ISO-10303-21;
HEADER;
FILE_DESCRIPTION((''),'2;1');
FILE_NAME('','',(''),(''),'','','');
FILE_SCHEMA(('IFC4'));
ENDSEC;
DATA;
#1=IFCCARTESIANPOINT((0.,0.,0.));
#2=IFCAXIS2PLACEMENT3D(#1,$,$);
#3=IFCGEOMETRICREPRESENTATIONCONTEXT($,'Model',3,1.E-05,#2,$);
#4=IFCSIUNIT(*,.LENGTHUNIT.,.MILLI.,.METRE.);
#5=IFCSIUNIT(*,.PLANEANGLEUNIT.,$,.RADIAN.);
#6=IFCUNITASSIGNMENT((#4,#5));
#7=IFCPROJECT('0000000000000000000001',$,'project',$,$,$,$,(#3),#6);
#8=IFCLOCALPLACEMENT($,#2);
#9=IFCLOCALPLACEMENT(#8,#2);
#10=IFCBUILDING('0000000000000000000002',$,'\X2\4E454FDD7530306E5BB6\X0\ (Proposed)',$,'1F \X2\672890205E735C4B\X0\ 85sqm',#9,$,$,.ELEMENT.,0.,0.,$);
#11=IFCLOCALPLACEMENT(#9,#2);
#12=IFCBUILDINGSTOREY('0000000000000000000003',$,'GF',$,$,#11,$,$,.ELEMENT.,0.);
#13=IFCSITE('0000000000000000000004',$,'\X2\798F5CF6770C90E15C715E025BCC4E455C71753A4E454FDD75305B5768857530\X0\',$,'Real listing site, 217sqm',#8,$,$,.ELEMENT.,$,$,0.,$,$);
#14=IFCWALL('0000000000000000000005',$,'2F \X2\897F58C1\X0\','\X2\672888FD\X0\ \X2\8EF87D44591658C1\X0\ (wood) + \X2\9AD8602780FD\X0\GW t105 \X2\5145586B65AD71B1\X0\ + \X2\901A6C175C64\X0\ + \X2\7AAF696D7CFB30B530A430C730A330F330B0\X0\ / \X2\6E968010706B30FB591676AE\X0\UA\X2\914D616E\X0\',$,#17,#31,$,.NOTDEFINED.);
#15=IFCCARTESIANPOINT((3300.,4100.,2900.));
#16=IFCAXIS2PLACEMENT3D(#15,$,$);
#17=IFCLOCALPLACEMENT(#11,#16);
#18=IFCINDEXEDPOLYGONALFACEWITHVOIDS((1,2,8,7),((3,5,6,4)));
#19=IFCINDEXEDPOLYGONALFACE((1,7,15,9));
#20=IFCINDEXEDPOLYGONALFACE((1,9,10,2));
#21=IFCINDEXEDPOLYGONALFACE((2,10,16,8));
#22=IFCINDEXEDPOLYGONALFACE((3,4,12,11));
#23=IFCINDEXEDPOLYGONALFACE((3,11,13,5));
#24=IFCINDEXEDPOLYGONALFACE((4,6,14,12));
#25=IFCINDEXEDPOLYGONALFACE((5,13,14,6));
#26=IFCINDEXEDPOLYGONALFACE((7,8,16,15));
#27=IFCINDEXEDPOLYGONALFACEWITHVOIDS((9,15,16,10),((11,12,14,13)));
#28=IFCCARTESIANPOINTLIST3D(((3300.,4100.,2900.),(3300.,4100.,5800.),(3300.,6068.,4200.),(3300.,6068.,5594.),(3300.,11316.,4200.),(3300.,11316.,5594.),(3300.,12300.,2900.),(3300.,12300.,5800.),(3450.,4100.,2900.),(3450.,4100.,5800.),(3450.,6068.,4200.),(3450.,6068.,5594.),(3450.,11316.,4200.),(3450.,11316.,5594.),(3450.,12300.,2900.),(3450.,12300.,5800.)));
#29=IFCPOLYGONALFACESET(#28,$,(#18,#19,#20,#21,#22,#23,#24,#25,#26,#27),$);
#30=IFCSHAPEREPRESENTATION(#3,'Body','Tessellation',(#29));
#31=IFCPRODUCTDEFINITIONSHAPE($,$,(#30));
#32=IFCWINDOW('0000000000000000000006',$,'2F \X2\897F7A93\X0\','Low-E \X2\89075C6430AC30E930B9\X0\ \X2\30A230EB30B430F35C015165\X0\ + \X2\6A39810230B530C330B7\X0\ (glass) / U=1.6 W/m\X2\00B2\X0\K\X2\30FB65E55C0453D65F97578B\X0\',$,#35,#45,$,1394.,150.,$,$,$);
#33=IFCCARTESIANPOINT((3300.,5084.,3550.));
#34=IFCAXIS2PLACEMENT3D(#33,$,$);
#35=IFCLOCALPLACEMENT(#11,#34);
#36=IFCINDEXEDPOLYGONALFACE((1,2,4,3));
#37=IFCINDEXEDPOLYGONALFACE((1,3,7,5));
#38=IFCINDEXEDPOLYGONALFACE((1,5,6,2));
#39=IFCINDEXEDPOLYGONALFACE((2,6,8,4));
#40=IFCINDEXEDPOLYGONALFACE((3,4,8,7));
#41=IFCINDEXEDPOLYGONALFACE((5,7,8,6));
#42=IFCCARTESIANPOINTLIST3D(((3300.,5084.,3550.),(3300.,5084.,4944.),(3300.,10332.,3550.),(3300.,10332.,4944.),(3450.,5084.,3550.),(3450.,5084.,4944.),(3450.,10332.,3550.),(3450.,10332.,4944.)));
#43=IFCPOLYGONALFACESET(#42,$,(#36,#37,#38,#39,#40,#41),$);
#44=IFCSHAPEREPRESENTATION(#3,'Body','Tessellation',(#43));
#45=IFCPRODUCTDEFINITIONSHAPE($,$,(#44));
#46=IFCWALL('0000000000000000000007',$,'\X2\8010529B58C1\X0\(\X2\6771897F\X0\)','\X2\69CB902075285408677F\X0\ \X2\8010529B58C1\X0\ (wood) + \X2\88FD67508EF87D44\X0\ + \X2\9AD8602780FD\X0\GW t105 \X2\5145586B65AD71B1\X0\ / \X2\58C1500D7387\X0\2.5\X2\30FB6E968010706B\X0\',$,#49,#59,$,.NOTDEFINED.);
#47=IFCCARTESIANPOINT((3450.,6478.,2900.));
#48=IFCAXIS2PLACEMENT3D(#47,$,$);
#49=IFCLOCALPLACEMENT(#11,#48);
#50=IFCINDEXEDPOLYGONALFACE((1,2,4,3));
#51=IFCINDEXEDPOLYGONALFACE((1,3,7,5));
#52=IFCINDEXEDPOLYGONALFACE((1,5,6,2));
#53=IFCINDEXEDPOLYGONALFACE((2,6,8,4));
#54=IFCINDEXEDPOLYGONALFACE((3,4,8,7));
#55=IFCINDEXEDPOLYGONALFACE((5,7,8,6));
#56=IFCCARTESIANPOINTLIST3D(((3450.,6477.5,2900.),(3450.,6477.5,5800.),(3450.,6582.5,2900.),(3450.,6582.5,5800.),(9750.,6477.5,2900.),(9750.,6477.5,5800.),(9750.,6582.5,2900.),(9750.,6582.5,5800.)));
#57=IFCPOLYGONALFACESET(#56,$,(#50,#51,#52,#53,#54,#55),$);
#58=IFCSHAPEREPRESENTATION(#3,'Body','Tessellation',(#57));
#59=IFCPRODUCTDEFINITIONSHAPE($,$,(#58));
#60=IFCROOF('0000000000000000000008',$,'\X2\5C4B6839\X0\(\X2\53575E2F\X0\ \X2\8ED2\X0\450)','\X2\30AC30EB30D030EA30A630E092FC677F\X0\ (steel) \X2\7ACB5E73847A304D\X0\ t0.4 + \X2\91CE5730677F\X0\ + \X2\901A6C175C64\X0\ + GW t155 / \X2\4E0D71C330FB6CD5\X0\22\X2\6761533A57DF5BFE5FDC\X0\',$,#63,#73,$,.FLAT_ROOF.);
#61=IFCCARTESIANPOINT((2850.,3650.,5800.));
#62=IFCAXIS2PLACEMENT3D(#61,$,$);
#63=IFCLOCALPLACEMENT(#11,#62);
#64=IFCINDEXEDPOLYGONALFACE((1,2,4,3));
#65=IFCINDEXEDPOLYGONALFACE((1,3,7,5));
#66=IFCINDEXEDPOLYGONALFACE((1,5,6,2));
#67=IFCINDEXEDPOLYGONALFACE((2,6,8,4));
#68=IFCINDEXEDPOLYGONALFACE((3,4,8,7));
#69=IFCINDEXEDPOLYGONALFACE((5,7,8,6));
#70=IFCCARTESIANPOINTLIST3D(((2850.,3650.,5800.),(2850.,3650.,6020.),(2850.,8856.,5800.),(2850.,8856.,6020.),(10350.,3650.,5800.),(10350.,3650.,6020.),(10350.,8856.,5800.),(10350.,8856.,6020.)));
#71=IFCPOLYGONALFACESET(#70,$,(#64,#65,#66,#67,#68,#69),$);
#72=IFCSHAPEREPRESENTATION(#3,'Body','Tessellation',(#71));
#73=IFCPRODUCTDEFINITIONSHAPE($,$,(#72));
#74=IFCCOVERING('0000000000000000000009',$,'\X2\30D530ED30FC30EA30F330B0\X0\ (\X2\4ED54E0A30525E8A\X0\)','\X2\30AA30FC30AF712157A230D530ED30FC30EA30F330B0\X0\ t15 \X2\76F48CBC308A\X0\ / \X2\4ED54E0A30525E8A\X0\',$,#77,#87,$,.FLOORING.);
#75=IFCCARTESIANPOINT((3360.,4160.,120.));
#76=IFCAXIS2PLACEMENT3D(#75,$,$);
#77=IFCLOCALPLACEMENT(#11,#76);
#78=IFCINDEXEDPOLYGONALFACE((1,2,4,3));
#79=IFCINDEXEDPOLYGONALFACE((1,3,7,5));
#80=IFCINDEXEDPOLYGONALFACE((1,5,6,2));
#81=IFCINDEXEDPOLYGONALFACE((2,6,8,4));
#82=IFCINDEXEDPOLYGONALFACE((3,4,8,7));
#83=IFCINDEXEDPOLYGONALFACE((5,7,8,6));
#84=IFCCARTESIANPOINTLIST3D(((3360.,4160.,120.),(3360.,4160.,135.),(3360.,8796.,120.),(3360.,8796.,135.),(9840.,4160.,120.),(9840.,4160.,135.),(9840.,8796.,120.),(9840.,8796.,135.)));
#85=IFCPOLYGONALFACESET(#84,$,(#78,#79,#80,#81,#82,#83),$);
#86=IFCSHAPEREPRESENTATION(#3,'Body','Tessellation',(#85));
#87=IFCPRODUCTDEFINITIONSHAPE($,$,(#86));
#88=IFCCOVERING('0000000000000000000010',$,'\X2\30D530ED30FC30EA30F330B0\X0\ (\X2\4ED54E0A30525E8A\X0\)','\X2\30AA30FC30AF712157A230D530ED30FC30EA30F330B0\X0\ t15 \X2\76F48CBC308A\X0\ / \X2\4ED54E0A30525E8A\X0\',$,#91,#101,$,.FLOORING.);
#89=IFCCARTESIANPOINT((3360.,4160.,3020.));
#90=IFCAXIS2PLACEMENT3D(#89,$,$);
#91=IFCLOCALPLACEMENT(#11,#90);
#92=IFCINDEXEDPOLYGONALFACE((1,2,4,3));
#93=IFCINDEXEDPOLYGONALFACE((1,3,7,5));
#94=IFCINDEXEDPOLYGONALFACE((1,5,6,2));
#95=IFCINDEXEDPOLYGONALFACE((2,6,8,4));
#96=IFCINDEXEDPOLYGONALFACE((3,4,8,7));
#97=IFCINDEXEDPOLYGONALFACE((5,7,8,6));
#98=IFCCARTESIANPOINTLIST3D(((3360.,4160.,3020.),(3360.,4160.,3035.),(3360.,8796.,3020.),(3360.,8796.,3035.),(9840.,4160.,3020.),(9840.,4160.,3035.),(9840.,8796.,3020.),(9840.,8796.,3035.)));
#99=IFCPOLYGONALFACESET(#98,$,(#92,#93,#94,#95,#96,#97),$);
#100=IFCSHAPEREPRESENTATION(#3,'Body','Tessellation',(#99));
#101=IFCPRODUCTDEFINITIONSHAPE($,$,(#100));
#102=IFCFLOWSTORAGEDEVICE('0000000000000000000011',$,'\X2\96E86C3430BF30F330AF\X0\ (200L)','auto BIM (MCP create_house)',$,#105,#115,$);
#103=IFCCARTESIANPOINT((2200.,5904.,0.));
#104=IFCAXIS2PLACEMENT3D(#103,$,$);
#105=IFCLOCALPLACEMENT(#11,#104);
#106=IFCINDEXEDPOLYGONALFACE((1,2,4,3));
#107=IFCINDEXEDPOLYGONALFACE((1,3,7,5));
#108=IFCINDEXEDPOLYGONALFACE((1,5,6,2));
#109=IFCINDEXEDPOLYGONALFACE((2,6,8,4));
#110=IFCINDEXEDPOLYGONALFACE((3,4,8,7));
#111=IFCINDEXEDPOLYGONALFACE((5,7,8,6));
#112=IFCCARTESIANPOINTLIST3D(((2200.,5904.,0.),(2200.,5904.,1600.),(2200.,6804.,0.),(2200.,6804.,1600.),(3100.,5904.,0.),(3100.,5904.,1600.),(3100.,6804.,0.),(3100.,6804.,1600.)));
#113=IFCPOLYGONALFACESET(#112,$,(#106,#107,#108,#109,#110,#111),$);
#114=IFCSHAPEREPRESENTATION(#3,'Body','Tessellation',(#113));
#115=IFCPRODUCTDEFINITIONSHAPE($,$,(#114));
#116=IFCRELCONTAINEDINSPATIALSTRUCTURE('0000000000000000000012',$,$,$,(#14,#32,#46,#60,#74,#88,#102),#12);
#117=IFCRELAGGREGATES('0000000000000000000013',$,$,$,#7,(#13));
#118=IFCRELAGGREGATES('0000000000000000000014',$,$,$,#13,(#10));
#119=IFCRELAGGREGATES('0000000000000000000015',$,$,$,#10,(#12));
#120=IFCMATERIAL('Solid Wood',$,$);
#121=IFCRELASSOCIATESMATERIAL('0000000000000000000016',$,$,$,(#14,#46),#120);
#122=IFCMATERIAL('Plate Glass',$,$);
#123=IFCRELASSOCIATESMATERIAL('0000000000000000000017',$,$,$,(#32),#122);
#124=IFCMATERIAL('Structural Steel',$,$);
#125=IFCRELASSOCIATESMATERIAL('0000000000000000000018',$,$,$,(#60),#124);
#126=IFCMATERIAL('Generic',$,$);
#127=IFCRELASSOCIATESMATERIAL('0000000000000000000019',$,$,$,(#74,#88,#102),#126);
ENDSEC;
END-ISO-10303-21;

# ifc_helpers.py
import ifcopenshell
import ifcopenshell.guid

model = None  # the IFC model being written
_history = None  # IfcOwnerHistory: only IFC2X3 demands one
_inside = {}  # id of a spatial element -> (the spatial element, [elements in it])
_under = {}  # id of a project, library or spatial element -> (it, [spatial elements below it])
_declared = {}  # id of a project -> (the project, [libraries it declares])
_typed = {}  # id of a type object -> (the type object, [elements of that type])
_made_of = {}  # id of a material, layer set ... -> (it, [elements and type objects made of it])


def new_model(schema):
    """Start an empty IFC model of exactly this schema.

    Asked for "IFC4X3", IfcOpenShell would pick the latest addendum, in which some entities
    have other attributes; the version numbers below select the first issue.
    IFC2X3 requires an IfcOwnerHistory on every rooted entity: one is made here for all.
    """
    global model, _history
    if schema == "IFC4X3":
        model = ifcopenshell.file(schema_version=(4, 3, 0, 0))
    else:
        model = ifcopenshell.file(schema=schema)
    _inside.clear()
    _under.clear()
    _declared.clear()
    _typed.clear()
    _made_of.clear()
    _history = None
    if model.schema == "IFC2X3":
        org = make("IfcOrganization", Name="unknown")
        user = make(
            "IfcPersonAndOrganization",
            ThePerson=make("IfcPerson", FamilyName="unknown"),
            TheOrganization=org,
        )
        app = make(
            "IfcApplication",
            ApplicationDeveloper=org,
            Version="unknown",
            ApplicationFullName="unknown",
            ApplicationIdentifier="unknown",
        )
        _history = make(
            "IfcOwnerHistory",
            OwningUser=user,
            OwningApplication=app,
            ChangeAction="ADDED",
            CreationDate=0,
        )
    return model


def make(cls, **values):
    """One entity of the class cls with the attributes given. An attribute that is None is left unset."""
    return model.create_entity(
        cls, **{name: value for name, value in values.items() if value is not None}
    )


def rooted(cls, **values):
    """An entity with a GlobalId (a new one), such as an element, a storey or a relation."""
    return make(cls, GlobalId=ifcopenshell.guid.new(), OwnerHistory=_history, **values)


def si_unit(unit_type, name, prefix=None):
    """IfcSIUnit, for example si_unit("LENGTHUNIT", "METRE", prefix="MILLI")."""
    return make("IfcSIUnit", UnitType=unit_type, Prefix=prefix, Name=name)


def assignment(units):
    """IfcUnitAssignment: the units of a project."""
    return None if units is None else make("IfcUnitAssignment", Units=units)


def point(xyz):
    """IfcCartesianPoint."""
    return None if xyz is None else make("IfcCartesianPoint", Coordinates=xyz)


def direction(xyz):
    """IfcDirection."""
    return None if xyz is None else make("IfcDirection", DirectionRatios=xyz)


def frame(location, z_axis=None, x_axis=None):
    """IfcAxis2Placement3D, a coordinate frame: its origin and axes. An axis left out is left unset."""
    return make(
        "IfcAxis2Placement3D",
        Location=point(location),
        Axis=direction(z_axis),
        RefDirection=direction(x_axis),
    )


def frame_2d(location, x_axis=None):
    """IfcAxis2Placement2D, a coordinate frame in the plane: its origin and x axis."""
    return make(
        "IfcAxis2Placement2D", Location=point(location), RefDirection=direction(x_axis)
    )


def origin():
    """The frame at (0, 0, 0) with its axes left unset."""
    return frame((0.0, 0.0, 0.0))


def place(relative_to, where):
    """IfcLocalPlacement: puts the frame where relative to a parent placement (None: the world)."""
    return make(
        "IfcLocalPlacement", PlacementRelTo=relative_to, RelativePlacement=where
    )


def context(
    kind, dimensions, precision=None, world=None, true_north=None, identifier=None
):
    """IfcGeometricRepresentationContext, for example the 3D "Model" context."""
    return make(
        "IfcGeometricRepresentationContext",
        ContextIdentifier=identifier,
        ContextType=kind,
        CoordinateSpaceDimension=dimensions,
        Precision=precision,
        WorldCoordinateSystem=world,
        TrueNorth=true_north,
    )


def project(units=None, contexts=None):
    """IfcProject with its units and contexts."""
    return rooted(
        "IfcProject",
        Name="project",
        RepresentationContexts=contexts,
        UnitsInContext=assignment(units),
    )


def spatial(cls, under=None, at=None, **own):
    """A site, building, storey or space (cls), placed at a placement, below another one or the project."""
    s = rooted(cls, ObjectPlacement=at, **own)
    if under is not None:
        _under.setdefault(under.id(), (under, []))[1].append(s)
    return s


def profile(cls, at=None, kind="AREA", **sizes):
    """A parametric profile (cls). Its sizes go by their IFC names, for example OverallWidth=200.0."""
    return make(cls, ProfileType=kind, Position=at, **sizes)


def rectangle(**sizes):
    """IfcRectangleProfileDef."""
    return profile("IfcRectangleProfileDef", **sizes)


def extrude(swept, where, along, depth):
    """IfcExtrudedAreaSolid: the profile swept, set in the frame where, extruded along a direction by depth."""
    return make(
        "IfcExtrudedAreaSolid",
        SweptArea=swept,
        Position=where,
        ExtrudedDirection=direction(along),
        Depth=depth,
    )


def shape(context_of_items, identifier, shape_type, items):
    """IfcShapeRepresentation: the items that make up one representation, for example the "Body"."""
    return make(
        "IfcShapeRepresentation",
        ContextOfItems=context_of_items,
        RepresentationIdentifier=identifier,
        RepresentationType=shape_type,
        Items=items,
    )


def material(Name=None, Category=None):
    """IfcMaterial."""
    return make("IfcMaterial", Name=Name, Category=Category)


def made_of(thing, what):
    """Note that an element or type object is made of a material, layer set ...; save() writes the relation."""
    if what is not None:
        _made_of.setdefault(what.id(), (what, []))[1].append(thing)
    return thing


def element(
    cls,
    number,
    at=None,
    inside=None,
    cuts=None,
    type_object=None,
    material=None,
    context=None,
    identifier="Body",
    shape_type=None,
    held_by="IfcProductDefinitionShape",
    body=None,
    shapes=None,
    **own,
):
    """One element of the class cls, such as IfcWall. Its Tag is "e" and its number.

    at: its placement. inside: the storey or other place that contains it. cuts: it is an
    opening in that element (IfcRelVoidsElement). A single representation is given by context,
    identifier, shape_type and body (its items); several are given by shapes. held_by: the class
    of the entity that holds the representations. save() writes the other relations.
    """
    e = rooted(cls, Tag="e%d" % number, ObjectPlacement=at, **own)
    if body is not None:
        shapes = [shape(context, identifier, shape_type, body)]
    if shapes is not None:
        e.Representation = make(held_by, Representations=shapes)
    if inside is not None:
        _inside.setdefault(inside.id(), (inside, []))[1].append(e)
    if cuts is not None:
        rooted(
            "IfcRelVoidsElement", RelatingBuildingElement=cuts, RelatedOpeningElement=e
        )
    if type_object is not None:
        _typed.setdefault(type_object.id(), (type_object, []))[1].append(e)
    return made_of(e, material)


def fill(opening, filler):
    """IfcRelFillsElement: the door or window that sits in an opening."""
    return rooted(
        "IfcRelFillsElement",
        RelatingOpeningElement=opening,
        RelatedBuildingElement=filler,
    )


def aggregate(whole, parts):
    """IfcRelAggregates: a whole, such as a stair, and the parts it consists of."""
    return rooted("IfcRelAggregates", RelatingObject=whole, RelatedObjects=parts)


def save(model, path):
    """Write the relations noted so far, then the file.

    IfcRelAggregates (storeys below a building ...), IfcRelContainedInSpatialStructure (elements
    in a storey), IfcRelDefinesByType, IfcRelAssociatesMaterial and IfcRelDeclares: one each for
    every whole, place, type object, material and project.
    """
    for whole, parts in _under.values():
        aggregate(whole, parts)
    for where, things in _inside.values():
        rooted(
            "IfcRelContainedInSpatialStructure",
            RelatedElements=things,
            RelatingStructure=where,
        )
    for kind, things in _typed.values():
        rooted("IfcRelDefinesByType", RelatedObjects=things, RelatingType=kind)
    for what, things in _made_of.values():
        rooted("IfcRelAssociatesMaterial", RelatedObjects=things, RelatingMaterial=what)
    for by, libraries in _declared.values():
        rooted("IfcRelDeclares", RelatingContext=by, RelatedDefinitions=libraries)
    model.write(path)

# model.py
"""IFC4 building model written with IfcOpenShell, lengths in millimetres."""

from ifc_helpers import new_model, si_unit, frame, frame_2d, origin, place, context, project, spatial, rectangle, extrude, material, element, fill, save


model = new_model("IFC4")

# Units and contexts
model_context = context("Model", 3, precision=1e-05, world=origin())
ifc_project = project(units=[si_unit("LENGTHUNIT", "METRE", prefix="MILLI"), si_unit("PLANEANGLEUNIT", "RADIAN")], contexts=[model_context])

# Site, building, storey
site_placement = place(None, origin())
site = spatial("IfcSite", under=ifc_project, at=site_placement, Name="福島県郡山市富久山町久保田字梅田", ObjectType="Real listing site, 217sqm", CompositionType="ELEMENT", RefElevation=0.0)
building_placement = place(site_placement, origin())
building = spatial("IfcBuilding", under=site, at=building_placement, Name="久保田の家 (Proposed)", ObjectType="1F 木造平屋 85sqm", CompositionType="ELEMENT", ElevationOfRefHeight=0.0, ElevationOfTerrain=0.0)
storey_placement = place(building_placement, origin())
storey = spatial("IfcBuildingStorey", under=building, at=storey_placement, Name="GF", CompositionType="ELEMENT", Elevation=0.0)

# Shared definitions
ifc_material_1 = material(Name="Solid Wood")
ifc_material_2 = material(Name="Generic")

# Shared definitions
ifc_material_3 = material(Name="Plate Glass")

# Wall, opening, window
wall_1_placement = place(storey_placement, frame((3300.0, 4100.0, 2900.0)))
wall_1 = element("IfcWall", 1, at=wall_1_placement, inside=storey, material=ifc_material_1, Name="2F 西壁", Description="木製 軸組外壁 (wood) + 高性能GW t105 充填断熱 + 通気層 + 窯業系サイディング / 準耐火・外皮UA配慮", PredefinedType="NOTDEFINED", context=model_context, shape_type="SweptSolid", body=[
    extrude(rectangle(XDim=150.0, YDim=8200.0, at=frame_2d((75.0, 4100.0))), frame((3300.0, 4100.0, 2900.0)), (0.0, 0.0, 1.0), 2900.0),
])
opening_1_placement = place(storey_placement, frame((3300.0, 5084.0, 3550.0)))
opening_1 = element("IfcOpeningElement", 2, at=opening_1_placement, cuts=wall_1, PredefinedType="NOTDEFINED", context=model_context, shape_type="SweptSolid", body=[
    extrude(rectangle(XDim=150.0, YDim=5248.0, at=frame_2d((75.0, 2624.0))), frame((3300.0, 5084.0, 3550.0)), (0.0, 0.0, 1.0), 1394.0),
])
window_1_placement = place(storey_placement, frame((3300.0, 5084.0, 3550.0)))
window_1 = element("IfcWindow", 3, at=window_1_placement, inside=storey, material=ifc_material_3, Name="2F 西窓", Description="Low-E 複層ガラス アルゴン封入 + 樹脂サッシ (glass) / U=1.6 W/m²K・日射取得型", OverallHeight=1394.0, OverallWidth=150.0, context=model_context, shape_type="SweptSolid", body=[
    extrude(rectangle(XDim=150.0, YDim=5248.0, at=frame_2d((75.0, 2624.0))), frame((3300.0, 5084.0, 3550.0)), (0.0, 0.0, 1.0), 1394.0),
])
fill(opening_1, window_1)

# Wall
wall_2_placement = place(storey_placement, frame((3450.0, 6478.0, 2900.0)))
element("IfcWall", 4, at=wall_2_placement, inside=storey, material=ifc_material_1, Name="耐力壁(東西)", Description="構造用合板 耐力壁 (wood) + 製材軸組 + 高性能GW t105 充填断熱 / 壁倍率2.5・準耐火", PredefinedType="NOTDEFINED", context=model_context, shape_type="SweptSolid", body=[
    extrude(rectangle(XDim=6300.0, YDim=105.0, at=frame_2d((3150.0, 52.0))), frame((3450.0, 6478.0, 2900.0)), (0.0, 0.0, 1.0), 2900.0),
])

# Roof
ifc_material_4 = material(Name="Structural Steel")
for number, where, name in (
    (5, (2850.0, 3650.0, 5800.0), "屋根(南帯 軒450)"),
):
    element("IfcRoof", number, at=place(storey_placement, frame(where)), inside=storey, material=ifc_material_4, Name=name, Description="ガルバリウム鋼板 (steel) 立平葺き t0.4 + 野地板 + 通気層 + GW t155 / 不燃・法22条区域対応", PredefinedType="FLAT_ROOF", context=model_context, shape_type="SweptSolid", body=[
        extrude(rectangle(XDim=7500.0, YDim=5206.0, at=frame_2d((3750.0, 2603.0))), frame((2850.0, 3650.0, 5800.0)), (0.0, 0.0, 1.0), 220.0),
    ])

# Coverings
covering_1_placement = place(storey_placement, frame((3360.0, 4160.0, 120.0)))
element("IfcCovering", 6, at=covering_1_placement, inside=storey, material=ifc_material_2, Name="フローリング (仕上げ床)", Description="オーク無垢フローリング t15 直貼り / 仕上げ床", PredefinedType="FLOORING", context=model_context, shape_type="SweptSolid", body=[
    extrude(rectangle(XDim=6480.0, YDim=4636.0, at=frame_2d((3240.0, 2318.0))), frame((3360.0, 4160.0, 120.0)), (0.0, 0.0, 1.0), 15.0),
])
covering_2_placement = place(storey_placement, frame((3360.0, 4160.0, 3020.0)))
element("IfcCovering", 7, at=covering_2_placement, inside=storey, material=ifc_material_2, Name="フローリング (仕上げ床)", Description="オーク無垢フローリング t15 直貼り / 仕上げ床", PredefinedType="FLOORING", context=model_context, shape_type="SweptSolid", body=[
    extrude(rectangle(XDim=6480.0, YDim=4636.0, at=frame_2d((3240.0, 2318.0))), frame((3360.0, 4160.0, 3020.0)), (0.0, 0.0, 1.0), 15.0),
])

# Flow storage device
flow_storage_device_placement = place(storey_placement, frame((2200.0, 5904.0, 0.0)))
element("IfcFlowStorageDevice", 8, at=flow_storage_device_placement, inside=storey, material=ifc_material_2, Name="雨水タンク (200L)", Description="auto BIM (MCP create_house)", context=model_context, shape_type="SweptSolid", body=[
    extrude(rectangle(XDim=900.0, YDim=900.0, at=frame_2d((450.0, 450.0))), frame((2200.0, 5904.0, 0.0)), (0.0, 0.0, 1.0), 1600.0),
])

save(model, "model.ifc")
